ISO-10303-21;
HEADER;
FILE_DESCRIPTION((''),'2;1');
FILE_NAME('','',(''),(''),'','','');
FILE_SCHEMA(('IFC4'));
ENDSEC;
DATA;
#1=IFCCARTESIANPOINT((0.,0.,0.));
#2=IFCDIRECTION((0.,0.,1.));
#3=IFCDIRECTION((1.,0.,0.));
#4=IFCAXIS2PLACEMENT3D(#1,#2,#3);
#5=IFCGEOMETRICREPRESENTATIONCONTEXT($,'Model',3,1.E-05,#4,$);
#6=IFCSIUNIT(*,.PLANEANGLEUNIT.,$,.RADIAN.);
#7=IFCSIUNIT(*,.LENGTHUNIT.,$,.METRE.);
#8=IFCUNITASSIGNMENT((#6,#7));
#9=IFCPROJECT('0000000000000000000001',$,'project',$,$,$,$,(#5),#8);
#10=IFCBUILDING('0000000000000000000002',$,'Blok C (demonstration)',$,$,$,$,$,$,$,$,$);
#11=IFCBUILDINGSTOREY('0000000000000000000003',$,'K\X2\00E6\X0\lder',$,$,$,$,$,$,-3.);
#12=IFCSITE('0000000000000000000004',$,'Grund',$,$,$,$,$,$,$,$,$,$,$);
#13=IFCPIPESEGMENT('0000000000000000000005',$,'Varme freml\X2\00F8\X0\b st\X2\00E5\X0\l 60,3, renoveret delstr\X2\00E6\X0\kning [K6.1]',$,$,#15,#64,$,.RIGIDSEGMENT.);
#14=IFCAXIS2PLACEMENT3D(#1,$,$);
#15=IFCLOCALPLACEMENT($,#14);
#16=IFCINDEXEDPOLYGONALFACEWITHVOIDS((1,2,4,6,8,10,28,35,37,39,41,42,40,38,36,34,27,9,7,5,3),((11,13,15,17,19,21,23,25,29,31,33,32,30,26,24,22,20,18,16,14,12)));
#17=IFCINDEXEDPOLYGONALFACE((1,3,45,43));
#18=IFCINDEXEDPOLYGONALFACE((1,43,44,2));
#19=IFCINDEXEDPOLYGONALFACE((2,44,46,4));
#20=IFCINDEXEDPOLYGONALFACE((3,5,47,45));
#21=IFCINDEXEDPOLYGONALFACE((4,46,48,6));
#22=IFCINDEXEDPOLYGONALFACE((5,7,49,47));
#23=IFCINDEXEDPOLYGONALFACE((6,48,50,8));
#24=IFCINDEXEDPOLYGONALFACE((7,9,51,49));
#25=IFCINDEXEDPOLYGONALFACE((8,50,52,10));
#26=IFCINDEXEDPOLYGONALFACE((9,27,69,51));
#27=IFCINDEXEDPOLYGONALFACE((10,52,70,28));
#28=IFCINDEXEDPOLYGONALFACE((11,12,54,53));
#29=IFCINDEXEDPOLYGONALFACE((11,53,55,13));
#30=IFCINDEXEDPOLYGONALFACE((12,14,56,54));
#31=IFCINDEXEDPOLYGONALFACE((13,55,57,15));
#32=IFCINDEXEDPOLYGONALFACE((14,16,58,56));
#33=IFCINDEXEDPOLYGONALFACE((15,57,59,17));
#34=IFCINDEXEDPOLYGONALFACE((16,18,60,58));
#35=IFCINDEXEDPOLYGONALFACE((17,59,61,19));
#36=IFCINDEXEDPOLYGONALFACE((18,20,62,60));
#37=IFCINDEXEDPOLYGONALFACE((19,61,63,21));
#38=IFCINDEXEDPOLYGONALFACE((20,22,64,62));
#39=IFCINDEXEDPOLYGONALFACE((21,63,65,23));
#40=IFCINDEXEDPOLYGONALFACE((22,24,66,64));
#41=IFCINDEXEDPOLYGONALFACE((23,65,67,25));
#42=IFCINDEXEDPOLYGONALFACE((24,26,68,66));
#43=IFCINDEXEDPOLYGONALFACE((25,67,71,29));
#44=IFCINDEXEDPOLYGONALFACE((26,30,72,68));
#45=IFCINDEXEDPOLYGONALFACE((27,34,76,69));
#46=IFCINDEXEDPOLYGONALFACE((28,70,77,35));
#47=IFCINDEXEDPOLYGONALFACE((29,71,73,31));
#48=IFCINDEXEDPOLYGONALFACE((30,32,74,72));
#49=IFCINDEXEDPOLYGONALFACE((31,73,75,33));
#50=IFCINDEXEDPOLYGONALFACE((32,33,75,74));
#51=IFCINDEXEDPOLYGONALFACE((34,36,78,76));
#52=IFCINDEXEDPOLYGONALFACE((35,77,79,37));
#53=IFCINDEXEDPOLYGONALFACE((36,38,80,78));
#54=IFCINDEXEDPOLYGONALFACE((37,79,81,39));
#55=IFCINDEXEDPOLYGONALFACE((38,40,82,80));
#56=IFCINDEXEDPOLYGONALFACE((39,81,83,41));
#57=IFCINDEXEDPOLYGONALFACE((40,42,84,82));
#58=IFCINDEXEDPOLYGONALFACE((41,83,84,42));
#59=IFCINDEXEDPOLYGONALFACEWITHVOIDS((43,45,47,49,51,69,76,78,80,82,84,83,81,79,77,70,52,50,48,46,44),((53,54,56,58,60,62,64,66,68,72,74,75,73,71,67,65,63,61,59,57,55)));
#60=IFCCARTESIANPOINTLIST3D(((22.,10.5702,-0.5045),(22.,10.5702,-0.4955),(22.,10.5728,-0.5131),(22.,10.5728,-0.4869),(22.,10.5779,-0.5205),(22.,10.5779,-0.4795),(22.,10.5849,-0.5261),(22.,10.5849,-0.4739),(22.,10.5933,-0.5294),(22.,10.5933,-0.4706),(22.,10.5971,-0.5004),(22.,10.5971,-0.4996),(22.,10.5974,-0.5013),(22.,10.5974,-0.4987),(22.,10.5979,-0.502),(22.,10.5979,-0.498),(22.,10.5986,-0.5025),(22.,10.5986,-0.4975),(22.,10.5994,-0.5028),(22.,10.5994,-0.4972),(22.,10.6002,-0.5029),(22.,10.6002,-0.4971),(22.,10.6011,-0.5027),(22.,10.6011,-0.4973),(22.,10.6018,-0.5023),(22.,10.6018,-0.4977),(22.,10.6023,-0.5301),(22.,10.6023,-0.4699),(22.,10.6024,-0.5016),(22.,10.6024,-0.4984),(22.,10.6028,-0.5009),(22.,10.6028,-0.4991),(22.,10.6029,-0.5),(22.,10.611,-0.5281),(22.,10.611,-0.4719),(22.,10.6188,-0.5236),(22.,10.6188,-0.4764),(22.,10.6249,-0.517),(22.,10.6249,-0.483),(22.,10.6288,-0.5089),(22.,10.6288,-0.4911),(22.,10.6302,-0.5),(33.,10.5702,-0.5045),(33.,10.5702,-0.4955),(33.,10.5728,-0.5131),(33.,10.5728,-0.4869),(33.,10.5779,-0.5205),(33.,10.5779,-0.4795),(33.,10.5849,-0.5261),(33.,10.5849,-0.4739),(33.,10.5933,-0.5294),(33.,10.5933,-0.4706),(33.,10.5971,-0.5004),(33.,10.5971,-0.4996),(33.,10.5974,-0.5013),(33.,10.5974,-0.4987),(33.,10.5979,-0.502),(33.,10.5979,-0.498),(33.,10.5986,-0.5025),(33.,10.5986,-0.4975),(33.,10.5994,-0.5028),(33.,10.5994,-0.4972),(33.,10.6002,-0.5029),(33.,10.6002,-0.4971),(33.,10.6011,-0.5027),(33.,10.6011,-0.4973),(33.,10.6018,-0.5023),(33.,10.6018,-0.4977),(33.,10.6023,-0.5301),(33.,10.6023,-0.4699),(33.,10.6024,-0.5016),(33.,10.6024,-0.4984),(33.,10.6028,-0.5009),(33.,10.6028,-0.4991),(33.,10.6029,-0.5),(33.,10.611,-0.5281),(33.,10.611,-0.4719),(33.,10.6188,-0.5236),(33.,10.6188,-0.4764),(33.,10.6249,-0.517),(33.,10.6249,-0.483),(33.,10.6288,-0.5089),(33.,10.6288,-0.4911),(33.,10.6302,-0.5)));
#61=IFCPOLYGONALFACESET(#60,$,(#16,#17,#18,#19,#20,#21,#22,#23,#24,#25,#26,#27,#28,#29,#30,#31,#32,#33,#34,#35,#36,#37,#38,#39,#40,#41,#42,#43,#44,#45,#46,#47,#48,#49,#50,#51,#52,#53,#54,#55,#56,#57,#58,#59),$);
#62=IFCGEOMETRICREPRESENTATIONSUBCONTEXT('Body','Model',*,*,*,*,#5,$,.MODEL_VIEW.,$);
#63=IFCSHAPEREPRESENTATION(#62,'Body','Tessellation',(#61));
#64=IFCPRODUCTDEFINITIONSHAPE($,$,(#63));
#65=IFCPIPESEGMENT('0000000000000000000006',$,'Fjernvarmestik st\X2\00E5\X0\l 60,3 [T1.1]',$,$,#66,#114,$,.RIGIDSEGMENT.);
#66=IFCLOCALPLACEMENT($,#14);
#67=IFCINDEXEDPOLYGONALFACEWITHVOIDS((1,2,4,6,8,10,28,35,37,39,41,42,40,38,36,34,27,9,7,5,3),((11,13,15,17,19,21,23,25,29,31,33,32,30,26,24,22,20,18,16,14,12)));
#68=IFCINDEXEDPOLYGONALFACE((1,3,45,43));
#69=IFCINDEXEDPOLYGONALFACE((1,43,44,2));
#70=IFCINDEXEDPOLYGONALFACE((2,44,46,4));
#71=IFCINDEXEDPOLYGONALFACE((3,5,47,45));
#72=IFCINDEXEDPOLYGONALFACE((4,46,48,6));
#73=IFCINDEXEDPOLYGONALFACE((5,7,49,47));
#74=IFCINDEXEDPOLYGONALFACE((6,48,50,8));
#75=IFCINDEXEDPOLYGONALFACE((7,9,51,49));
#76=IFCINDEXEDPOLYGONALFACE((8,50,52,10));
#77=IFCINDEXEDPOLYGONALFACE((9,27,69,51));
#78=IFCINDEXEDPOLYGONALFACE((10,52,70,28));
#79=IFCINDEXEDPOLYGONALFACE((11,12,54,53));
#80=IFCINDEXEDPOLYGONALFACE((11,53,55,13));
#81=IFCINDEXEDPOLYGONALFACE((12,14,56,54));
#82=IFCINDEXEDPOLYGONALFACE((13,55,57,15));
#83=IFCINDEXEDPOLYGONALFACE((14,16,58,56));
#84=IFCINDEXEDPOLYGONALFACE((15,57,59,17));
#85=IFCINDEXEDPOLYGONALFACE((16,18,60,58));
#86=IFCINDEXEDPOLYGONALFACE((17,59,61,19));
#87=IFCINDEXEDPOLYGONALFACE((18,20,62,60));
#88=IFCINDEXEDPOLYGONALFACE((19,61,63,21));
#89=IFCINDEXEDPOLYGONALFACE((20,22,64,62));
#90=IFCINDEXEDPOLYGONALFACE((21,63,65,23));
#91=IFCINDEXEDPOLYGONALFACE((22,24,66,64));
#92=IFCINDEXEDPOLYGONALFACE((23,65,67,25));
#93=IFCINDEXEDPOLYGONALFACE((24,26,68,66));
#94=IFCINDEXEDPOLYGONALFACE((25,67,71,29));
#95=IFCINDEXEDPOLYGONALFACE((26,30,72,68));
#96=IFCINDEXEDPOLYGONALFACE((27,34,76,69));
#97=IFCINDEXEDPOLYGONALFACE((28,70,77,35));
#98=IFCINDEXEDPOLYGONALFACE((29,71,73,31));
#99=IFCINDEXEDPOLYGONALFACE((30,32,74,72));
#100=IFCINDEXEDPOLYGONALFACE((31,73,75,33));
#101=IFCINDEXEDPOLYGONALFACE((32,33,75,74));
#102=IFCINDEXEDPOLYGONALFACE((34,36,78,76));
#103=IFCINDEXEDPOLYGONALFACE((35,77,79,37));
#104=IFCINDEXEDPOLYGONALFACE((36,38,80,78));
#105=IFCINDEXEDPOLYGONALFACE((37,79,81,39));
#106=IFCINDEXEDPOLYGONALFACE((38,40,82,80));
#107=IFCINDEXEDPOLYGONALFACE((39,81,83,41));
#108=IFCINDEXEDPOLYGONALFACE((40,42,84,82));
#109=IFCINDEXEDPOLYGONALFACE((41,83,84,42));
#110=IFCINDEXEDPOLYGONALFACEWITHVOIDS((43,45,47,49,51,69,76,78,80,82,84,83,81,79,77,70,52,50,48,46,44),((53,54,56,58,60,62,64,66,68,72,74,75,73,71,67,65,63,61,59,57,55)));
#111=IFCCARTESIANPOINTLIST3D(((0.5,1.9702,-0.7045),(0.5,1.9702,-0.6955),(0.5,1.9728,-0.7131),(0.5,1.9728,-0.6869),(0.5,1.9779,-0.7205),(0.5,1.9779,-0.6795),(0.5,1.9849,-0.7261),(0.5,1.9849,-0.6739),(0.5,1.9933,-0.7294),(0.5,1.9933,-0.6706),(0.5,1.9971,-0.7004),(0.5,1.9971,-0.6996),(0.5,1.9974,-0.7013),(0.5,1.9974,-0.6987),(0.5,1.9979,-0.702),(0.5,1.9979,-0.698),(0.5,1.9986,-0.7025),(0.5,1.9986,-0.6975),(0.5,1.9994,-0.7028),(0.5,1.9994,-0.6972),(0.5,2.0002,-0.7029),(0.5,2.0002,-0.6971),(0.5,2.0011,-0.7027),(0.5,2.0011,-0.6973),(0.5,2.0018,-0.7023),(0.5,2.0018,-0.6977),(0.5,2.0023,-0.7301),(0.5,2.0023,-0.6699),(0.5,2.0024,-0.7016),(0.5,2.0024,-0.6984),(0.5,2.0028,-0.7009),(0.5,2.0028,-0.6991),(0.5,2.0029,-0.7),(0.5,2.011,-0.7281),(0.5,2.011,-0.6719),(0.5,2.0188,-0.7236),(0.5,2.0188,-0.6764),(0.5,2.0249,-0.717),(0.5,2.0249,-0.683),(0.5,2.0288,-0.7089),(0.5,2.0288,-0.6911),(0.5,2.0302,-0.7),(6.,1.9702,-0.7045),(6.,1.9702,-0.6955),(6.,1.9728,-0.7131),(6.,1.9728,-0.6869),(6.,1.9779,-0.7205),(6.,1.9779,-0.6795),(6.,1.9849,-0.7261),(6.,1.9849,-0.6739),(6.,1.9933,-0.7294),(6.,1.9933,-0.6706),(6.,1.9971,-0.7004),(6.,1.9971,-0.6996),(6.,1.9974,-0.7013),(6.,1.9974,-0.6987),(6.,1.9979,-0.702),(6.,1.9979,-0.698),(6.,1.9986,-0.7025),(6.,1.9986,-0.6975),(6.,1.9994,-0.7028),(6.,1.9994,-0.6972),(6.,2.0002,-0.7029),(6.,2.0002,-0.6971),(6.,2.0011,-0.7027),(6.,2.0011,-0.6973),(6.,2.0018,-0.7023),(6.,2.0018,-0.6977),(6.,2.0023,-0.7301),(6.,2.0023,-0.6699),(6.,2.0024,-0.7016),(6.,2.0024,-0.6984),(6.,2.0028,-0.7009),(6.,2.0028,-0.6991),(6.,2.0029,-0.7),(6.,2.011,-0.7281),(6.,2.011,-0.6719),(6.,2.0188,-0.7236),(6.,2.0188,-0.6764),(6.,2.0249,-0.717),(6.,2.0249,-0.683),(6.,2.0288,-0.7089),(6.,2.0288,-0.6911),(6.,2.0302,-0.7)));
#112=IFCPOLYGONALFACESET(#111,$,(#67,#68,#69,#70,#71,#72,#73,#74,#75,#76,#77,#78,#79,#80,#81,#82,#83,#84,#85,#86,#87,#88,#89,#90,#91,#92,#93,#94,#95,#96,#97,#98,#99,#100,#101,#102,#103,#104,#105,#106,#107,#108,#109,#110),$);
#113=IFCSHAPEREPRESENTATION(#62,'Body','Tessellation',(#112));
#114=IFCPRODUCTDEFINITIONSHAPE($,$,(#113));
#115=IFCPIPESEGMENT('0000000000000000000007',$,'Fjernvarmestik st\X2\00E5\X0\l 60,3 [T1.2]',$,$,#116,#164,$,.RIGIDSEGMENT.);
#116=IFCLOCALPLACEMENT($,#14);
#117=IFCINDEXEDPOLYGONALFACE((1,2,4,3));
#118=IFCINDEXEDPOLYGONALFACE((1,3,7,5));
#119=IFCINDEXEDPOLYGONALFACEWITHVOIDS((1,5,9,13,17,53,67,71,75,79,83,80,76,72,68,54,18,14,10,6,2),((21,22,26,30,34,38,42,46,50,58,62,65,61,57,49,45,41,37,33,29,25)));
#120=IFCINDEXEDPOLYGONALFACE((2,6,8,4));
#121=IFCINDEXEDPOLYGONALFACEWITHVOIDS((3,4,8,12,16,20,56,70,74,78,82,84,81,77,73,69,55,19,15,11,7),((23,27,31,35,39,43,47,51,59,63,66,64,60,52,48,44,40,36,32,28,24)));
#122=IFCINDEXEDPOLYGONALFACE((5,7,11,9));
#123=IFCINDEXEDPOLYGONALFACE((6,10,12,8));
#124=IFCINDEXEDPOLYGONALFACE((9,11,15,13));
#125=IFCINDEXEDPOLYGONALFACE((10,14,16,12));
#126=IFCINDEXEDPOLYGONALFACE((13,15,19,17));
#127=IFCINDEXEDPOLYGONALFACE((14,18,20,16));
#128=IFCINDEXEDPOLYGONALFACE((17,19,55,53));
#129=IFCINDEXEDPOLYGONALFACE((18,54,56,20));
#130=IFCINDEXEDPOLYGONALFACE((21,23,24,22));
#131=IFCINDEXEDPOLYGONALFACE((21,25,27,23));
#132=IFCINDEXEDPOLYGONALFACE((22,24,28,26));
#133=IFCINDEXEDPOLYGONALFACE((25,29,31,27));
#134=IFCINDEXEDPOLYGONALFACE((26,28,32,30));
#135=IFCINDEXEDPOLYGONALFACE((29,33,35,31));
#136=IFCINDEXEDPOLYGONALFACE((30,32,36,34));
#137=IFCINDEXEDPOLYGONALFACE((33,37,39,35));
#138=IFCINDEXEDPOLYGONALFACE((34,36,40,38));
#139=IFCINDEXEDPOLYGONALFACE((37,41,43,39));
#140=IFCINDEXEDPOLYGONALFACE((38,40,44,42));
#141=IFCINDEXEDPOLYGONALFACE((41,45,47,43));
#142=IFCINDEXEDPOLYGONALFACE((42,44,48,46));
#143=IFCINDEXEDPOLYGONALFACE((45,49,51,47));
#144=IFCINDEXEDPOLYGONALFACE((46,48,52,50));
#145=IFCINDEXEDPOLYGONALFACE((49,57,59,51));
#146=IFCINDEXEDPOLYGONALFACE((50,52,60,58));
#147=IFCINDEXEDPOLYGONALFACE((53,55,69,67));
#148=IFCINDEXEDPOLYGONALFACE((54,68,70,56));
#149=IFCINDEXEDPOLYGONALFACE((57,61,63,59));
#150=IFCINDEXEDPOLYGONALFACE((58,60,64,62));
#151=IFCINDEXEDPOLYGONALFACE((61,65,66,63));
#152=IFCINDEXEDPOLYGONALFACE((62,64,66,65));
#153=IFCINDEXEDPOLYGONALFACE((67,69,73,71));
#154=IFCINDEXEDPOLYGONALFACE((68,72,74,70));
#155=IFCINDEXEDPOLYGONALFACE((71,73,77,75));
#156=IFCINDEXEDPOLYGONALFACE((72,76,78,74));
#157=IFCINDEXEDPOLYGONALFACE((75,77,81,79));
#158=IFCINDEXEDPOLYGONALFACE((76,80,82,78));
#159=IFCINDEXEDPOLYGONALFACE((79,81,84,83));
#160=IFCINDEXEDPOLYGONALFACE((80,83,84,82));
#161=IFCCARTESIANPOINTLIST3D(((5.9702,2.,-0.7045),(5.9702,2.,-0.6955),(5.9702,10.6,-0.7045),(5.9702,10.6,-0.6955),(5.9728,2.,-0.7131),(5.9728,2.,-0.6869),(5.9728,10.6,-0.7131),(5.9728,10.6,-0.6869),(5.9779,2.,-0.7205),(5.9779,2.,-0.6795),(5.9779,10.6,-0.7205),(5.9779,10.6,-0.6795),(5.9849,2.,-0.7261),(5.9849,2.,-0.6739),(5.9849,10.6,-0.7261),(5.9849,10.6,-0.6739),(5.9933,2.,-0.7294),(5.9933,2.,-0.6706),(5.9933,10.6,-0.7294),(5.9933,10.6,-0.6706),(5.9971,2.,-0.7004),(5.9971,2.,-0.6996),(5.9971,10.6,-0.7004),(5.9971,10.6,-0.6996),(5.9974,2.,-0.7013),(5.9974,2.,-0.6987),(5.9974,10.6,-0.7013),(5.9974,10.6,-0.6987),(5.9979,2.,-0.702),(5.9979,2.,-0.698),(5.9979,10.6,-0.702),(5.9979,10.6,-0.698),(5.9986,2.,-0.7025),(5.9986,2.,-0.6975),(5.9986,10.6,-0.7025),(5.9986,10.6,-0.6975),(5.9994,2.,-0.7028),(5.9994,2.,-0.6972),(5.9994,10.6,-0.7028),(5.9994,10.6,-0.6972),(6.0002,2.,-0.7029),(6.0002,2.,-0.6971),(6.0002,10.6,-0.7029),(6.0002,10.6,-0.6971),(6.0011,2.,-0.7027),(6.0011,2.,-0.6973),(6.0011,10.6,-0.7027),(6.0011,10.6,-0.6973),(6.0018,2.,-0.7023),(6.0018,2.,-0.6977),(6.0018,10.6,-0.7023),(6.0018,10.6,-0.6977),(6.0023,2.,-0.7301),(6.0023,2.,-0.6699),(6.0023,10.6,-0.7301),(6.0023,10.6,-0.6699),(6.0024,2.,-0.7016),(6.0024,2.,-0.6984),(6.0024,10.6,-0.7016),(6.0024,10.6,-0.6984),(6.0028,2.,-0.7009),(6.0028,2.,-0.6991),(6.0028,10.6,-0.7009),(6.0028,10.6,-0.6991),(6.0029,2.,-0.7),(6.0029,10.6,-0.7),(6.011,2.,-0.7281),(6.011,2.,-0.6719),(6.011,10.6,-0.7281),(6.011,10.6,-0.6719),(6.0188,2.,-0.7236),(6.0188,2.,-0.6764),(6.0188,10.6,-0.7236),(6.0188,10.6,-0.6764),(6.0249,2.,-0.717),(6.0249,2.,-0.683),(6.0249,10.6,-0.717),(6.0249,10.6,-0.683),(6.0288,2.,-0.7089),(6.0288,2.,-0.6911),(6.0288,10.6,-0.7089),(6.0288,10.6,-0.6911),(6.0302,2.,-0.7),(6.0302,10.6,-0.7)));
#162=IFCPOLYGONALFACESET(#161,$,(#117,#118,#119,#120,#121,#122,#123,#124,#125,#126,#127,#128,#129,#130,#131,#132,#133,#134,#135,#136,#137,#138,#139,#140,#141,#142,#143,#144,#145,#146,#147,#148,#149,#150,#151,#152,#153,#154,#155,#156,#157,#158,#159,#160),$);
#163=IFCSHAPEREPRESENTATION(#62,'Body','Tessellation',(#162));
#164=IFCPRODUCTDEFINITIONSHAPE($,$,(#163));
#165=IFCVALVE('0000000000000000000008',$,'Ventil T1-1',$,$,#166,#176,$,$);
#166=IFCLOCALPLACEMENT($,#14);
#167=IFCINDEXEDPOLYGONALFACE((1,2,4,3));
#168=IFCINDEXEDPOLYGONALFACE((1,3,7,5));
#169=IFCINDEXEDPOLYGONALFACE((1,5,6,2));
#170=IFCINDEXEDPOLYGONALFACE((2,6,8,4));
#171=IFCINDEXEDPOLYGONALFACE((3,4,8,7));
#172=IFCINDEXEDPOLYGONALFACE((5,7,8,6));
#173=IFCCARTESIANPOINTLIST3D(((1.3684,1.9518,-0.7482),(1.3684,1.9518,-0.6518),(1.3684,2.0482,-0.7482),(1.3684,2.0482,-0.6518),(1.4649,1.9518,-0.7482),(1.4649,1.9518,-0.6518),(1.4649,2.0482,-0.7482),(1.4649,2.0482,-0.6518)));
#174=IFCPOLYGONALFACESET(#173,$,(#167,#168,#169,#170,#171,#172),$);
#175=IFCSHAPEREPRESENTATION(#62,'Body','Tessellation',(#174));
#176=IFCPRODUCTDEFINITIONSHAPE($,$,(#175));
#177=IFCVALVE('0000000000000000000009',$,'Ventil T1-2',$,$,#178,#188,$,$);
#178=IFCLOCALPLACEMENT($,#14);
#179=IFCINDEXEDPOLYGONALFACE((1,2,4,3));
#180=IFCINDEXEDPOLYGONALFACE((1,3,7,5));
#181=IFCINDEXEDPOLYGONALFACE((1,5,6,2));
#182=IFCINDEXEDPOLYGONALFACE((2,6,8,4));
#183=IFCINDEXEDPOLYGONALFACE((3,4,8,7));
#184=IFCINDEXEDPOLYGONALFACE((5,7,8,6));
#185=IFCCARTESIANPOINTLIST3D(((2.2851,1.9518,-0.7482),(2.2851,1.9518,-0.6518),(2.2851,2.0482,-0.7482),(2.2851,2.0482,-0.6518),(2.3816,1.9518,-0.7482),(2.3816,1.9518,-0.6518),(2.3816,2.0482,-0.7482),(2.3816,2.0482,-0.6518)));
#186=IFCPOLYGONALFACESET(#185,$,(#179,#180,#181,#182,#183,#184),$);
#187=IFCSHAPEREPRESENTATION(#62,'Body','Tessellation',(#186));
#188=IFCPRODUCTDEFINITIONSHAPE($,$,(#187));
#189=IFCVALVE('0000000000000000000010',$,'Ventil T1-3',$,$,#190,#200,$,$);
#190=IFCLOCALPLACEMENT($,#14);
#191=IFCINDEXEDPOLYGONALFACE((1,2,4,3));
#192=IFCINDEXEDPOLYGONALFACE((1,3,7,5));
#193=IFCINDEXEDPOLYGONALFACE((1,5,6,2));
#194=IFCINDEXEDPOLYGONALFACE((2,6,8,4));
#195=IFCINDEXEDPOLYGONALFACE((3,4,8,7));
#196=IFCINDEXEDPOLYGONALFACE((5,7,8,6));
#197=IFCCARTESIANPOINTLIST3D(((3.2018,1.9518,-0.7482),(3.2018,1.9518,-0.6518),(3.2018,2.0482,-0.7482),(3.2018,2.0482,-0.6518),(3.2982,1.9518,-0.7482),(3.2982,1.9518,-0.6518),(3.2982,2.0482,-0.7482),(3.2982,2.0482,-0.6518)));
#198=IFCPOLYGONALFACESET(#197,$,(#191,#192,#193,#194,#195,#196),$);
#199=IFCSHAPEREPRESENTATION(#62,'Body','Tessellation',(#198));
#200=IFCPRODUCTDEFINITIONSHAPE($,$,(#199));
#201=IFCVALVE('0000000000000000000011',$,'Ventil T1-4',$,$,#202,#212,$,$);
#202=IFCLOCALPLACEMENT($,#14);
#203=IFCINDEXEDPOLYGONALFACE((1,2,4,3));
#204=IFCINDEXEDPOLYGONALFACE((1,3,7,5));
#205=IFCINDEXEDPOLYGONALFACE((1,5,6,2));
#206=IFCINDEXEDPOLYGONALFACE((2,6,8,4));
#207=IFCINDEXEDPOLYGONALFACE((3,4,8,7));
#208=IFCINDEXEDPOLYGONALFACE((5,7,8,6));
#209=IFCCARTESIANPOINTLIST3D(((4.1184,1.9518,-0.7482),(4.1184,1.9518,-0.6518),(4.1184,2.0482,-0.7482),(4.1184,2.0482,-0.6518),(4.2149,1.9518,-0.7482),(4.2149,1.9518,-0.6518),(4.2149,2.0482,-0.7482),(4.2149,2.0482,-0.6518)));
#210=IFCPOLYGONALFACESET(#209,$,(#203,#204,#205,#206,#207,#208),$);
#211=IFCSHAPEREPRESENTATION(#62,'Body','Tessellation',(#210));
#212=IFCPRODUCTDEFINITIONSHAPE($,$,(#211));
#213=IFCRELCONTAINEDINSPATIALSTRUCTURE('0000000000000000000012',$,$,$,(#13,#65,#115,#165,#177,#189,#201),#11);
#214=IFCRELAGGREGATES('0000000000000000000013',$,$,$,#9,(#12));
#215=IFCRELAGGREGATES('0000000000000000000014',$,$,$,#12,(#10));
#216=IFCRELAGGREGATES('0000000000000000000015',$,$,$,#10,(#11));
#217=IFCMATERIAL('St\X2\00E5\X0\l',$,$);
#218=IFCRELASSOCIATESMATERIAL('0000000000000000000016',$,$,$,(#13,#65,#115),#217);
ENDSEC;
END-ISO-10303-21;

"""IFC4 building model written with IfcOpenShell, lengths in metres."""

from ifc_helpers import new_model, si_unit, frame, origin_with_axes, place, context, subcontext, project, spatial, polyline, hollow_circle, outline, extrude, material, element, save


model = new_model("IFC4")

# Units and contexts
model_context = context("Model", 3, precision=1e-05, world=origin_with_axes())
body_context = subcontext(model_context, "Body", "Model", "MODEL_VIEW")
ifc_project = project(units=[si_unit("PLANEANGLEUNIT", "RADIAN"), si_unit("LENGTHUNIT", "METRE")], contexts=[model_context])

# Site, building, storey
site = spatial("IfcSite", under=ifc_project, Name="Grund")
building = spatial("IfcBuilding", under=site, Name="Blok C (demonstration)")
storey = spatial("IfcBuildingStorey", under=building, Name="Kælder", Elevation=-3.0)

# Shared definitions
ifc_material_1 = material(Name="Stål")

# Pipe segments
pipe_segment_1_placement = place(None, origin_with_axes())
element("IfcPipeSegment", 1, at=pipe_segment_1_placement, inside=storey, material=ifc_material_1, Name="Varme fremløb stål 60,3, renoveret delstrækning [K6.1]", PredefinedType="RIGIDSEGMENT", context=body_context, shape_type="SweptSolid", body=[
    extrude(hollow_circle(Radius=0.0301, WallThickness=0.0272), frame((22.0, 10.6, -0.5), z_axis=(1.0, 0.0, 0.0), x_axis=(0.0, 1.0, 0.0)), (0.0, 0.0, 1.0), 11.0),
])
pipe_segment_2_placement = place(None, origin_with_axes())
element("IfcPipeSegment", 2, at=pipe_segment_2_placement, inside=storey, material=ifc_material_1, Name="Fjernvarmestik stål 60,3 [T1.1]", PredefinedType="RIGIDSEGMENT", context=body_context, shape_type="SweptSolid", body=[
    extrude(hollow_circle(Radius=0.0301, WallThickness=0.0272), frame((0.5, 2.0, -0.7), z_axis=(1.0, 0.0, 0.0), x_axis=(0.0, 1.0, 0.0)), (0.0, 0.0, 1.0), 5.5),
])
pipe_segment_3_placement = place(None, origin_with_axes())
element("IfcPipeSegment", 3, at=pipe_segment_3_placement, inside=storey, material=ifc_material_1, Name="Fjernvarmestik stål 60,3 [T1.2]", PredefinedType="RIGIDSEGMENT", context=body_context, shape_type="SweptSolid", body=[
    extrude(hollow_circle(Radius=0.0301, WallThickness=0.0272), frame((6.0, 2.0, -0.7), z_axis=(0.0, 1.0, 0.0), x_axis=(1.0, 0.0, 0.0)), (0.0, 0.0, 1.0), 8.6),
])

# Valves
valve_1_placement = place(None, origin_with_axes())
element("IfcValve", 4, at=valve_1_placement, inside=storey, Name="Ventil T1-1", context=body_context, shape_type="SweptSolid", body=[
    extrude(outline(polyline([(1.3684, 1.9518), (1.4649, 1.9518), (1.4649, 2.0482), (1.3684, 2.0482), (1.3684, 1.9518)])), frame((0.0, 0.0, -0.7482)), (0.0, 0.0, 1.0), 0.0965),
])
valve_2_placement = place(None, origin_with_axes())
element("IfcValve", 5, at=valve_2_placement, inside=storey, Name="Ventil T1-2", context=body_context, shape_type="SweptSolid", body=[
    extrude(outline(polyline([(2.2851, 1.9518), (2.3816, 1.9518), (2.3816, 2.0482), (2.2851, 2.0482), (2.2851, 1.9518)])), frame((0.0, 0.0, -0.7482)), (0.0, 0.0, 1.0), 0.0965),
])
valve_3_placement = place(None, origin_with_axes())
element("IfcValve", 6, at=valve_3_placement, inside=storey, Name="Ventil T1-3", context=body_context, shape_type="SweptSolid", body=[
    extrude(outline(polyline([(3.2018, 1.9518), (3.2982, 1.9518), (3.2982, 2.0482), (3.2018, 2.0482), (3.2018, 1.9518)])), frame((0.0, 0.0, -0.7482)), (0.0, 0.0, 1.0), 0.0965),
])
valve_4_placement = place(None, origin_with_axes())
element("IfcValve", 7, at=valve_4_placement, inside=storey, Name="Ventil T1-4", context=body_context, shape_type="SweptSolid", body=[
    extrude(outline(polyline([(4.1184, 1.9518), (4.2149, 1.9518), (4.2149, 2.0482), (4.1184, 2.0482), (4.1184, 1.9518)])), frame((0.0, 0.0, -0.7482)), (0.0, 0.0, 1.0), 0.0965),
])

save(model, "model.ifc")
